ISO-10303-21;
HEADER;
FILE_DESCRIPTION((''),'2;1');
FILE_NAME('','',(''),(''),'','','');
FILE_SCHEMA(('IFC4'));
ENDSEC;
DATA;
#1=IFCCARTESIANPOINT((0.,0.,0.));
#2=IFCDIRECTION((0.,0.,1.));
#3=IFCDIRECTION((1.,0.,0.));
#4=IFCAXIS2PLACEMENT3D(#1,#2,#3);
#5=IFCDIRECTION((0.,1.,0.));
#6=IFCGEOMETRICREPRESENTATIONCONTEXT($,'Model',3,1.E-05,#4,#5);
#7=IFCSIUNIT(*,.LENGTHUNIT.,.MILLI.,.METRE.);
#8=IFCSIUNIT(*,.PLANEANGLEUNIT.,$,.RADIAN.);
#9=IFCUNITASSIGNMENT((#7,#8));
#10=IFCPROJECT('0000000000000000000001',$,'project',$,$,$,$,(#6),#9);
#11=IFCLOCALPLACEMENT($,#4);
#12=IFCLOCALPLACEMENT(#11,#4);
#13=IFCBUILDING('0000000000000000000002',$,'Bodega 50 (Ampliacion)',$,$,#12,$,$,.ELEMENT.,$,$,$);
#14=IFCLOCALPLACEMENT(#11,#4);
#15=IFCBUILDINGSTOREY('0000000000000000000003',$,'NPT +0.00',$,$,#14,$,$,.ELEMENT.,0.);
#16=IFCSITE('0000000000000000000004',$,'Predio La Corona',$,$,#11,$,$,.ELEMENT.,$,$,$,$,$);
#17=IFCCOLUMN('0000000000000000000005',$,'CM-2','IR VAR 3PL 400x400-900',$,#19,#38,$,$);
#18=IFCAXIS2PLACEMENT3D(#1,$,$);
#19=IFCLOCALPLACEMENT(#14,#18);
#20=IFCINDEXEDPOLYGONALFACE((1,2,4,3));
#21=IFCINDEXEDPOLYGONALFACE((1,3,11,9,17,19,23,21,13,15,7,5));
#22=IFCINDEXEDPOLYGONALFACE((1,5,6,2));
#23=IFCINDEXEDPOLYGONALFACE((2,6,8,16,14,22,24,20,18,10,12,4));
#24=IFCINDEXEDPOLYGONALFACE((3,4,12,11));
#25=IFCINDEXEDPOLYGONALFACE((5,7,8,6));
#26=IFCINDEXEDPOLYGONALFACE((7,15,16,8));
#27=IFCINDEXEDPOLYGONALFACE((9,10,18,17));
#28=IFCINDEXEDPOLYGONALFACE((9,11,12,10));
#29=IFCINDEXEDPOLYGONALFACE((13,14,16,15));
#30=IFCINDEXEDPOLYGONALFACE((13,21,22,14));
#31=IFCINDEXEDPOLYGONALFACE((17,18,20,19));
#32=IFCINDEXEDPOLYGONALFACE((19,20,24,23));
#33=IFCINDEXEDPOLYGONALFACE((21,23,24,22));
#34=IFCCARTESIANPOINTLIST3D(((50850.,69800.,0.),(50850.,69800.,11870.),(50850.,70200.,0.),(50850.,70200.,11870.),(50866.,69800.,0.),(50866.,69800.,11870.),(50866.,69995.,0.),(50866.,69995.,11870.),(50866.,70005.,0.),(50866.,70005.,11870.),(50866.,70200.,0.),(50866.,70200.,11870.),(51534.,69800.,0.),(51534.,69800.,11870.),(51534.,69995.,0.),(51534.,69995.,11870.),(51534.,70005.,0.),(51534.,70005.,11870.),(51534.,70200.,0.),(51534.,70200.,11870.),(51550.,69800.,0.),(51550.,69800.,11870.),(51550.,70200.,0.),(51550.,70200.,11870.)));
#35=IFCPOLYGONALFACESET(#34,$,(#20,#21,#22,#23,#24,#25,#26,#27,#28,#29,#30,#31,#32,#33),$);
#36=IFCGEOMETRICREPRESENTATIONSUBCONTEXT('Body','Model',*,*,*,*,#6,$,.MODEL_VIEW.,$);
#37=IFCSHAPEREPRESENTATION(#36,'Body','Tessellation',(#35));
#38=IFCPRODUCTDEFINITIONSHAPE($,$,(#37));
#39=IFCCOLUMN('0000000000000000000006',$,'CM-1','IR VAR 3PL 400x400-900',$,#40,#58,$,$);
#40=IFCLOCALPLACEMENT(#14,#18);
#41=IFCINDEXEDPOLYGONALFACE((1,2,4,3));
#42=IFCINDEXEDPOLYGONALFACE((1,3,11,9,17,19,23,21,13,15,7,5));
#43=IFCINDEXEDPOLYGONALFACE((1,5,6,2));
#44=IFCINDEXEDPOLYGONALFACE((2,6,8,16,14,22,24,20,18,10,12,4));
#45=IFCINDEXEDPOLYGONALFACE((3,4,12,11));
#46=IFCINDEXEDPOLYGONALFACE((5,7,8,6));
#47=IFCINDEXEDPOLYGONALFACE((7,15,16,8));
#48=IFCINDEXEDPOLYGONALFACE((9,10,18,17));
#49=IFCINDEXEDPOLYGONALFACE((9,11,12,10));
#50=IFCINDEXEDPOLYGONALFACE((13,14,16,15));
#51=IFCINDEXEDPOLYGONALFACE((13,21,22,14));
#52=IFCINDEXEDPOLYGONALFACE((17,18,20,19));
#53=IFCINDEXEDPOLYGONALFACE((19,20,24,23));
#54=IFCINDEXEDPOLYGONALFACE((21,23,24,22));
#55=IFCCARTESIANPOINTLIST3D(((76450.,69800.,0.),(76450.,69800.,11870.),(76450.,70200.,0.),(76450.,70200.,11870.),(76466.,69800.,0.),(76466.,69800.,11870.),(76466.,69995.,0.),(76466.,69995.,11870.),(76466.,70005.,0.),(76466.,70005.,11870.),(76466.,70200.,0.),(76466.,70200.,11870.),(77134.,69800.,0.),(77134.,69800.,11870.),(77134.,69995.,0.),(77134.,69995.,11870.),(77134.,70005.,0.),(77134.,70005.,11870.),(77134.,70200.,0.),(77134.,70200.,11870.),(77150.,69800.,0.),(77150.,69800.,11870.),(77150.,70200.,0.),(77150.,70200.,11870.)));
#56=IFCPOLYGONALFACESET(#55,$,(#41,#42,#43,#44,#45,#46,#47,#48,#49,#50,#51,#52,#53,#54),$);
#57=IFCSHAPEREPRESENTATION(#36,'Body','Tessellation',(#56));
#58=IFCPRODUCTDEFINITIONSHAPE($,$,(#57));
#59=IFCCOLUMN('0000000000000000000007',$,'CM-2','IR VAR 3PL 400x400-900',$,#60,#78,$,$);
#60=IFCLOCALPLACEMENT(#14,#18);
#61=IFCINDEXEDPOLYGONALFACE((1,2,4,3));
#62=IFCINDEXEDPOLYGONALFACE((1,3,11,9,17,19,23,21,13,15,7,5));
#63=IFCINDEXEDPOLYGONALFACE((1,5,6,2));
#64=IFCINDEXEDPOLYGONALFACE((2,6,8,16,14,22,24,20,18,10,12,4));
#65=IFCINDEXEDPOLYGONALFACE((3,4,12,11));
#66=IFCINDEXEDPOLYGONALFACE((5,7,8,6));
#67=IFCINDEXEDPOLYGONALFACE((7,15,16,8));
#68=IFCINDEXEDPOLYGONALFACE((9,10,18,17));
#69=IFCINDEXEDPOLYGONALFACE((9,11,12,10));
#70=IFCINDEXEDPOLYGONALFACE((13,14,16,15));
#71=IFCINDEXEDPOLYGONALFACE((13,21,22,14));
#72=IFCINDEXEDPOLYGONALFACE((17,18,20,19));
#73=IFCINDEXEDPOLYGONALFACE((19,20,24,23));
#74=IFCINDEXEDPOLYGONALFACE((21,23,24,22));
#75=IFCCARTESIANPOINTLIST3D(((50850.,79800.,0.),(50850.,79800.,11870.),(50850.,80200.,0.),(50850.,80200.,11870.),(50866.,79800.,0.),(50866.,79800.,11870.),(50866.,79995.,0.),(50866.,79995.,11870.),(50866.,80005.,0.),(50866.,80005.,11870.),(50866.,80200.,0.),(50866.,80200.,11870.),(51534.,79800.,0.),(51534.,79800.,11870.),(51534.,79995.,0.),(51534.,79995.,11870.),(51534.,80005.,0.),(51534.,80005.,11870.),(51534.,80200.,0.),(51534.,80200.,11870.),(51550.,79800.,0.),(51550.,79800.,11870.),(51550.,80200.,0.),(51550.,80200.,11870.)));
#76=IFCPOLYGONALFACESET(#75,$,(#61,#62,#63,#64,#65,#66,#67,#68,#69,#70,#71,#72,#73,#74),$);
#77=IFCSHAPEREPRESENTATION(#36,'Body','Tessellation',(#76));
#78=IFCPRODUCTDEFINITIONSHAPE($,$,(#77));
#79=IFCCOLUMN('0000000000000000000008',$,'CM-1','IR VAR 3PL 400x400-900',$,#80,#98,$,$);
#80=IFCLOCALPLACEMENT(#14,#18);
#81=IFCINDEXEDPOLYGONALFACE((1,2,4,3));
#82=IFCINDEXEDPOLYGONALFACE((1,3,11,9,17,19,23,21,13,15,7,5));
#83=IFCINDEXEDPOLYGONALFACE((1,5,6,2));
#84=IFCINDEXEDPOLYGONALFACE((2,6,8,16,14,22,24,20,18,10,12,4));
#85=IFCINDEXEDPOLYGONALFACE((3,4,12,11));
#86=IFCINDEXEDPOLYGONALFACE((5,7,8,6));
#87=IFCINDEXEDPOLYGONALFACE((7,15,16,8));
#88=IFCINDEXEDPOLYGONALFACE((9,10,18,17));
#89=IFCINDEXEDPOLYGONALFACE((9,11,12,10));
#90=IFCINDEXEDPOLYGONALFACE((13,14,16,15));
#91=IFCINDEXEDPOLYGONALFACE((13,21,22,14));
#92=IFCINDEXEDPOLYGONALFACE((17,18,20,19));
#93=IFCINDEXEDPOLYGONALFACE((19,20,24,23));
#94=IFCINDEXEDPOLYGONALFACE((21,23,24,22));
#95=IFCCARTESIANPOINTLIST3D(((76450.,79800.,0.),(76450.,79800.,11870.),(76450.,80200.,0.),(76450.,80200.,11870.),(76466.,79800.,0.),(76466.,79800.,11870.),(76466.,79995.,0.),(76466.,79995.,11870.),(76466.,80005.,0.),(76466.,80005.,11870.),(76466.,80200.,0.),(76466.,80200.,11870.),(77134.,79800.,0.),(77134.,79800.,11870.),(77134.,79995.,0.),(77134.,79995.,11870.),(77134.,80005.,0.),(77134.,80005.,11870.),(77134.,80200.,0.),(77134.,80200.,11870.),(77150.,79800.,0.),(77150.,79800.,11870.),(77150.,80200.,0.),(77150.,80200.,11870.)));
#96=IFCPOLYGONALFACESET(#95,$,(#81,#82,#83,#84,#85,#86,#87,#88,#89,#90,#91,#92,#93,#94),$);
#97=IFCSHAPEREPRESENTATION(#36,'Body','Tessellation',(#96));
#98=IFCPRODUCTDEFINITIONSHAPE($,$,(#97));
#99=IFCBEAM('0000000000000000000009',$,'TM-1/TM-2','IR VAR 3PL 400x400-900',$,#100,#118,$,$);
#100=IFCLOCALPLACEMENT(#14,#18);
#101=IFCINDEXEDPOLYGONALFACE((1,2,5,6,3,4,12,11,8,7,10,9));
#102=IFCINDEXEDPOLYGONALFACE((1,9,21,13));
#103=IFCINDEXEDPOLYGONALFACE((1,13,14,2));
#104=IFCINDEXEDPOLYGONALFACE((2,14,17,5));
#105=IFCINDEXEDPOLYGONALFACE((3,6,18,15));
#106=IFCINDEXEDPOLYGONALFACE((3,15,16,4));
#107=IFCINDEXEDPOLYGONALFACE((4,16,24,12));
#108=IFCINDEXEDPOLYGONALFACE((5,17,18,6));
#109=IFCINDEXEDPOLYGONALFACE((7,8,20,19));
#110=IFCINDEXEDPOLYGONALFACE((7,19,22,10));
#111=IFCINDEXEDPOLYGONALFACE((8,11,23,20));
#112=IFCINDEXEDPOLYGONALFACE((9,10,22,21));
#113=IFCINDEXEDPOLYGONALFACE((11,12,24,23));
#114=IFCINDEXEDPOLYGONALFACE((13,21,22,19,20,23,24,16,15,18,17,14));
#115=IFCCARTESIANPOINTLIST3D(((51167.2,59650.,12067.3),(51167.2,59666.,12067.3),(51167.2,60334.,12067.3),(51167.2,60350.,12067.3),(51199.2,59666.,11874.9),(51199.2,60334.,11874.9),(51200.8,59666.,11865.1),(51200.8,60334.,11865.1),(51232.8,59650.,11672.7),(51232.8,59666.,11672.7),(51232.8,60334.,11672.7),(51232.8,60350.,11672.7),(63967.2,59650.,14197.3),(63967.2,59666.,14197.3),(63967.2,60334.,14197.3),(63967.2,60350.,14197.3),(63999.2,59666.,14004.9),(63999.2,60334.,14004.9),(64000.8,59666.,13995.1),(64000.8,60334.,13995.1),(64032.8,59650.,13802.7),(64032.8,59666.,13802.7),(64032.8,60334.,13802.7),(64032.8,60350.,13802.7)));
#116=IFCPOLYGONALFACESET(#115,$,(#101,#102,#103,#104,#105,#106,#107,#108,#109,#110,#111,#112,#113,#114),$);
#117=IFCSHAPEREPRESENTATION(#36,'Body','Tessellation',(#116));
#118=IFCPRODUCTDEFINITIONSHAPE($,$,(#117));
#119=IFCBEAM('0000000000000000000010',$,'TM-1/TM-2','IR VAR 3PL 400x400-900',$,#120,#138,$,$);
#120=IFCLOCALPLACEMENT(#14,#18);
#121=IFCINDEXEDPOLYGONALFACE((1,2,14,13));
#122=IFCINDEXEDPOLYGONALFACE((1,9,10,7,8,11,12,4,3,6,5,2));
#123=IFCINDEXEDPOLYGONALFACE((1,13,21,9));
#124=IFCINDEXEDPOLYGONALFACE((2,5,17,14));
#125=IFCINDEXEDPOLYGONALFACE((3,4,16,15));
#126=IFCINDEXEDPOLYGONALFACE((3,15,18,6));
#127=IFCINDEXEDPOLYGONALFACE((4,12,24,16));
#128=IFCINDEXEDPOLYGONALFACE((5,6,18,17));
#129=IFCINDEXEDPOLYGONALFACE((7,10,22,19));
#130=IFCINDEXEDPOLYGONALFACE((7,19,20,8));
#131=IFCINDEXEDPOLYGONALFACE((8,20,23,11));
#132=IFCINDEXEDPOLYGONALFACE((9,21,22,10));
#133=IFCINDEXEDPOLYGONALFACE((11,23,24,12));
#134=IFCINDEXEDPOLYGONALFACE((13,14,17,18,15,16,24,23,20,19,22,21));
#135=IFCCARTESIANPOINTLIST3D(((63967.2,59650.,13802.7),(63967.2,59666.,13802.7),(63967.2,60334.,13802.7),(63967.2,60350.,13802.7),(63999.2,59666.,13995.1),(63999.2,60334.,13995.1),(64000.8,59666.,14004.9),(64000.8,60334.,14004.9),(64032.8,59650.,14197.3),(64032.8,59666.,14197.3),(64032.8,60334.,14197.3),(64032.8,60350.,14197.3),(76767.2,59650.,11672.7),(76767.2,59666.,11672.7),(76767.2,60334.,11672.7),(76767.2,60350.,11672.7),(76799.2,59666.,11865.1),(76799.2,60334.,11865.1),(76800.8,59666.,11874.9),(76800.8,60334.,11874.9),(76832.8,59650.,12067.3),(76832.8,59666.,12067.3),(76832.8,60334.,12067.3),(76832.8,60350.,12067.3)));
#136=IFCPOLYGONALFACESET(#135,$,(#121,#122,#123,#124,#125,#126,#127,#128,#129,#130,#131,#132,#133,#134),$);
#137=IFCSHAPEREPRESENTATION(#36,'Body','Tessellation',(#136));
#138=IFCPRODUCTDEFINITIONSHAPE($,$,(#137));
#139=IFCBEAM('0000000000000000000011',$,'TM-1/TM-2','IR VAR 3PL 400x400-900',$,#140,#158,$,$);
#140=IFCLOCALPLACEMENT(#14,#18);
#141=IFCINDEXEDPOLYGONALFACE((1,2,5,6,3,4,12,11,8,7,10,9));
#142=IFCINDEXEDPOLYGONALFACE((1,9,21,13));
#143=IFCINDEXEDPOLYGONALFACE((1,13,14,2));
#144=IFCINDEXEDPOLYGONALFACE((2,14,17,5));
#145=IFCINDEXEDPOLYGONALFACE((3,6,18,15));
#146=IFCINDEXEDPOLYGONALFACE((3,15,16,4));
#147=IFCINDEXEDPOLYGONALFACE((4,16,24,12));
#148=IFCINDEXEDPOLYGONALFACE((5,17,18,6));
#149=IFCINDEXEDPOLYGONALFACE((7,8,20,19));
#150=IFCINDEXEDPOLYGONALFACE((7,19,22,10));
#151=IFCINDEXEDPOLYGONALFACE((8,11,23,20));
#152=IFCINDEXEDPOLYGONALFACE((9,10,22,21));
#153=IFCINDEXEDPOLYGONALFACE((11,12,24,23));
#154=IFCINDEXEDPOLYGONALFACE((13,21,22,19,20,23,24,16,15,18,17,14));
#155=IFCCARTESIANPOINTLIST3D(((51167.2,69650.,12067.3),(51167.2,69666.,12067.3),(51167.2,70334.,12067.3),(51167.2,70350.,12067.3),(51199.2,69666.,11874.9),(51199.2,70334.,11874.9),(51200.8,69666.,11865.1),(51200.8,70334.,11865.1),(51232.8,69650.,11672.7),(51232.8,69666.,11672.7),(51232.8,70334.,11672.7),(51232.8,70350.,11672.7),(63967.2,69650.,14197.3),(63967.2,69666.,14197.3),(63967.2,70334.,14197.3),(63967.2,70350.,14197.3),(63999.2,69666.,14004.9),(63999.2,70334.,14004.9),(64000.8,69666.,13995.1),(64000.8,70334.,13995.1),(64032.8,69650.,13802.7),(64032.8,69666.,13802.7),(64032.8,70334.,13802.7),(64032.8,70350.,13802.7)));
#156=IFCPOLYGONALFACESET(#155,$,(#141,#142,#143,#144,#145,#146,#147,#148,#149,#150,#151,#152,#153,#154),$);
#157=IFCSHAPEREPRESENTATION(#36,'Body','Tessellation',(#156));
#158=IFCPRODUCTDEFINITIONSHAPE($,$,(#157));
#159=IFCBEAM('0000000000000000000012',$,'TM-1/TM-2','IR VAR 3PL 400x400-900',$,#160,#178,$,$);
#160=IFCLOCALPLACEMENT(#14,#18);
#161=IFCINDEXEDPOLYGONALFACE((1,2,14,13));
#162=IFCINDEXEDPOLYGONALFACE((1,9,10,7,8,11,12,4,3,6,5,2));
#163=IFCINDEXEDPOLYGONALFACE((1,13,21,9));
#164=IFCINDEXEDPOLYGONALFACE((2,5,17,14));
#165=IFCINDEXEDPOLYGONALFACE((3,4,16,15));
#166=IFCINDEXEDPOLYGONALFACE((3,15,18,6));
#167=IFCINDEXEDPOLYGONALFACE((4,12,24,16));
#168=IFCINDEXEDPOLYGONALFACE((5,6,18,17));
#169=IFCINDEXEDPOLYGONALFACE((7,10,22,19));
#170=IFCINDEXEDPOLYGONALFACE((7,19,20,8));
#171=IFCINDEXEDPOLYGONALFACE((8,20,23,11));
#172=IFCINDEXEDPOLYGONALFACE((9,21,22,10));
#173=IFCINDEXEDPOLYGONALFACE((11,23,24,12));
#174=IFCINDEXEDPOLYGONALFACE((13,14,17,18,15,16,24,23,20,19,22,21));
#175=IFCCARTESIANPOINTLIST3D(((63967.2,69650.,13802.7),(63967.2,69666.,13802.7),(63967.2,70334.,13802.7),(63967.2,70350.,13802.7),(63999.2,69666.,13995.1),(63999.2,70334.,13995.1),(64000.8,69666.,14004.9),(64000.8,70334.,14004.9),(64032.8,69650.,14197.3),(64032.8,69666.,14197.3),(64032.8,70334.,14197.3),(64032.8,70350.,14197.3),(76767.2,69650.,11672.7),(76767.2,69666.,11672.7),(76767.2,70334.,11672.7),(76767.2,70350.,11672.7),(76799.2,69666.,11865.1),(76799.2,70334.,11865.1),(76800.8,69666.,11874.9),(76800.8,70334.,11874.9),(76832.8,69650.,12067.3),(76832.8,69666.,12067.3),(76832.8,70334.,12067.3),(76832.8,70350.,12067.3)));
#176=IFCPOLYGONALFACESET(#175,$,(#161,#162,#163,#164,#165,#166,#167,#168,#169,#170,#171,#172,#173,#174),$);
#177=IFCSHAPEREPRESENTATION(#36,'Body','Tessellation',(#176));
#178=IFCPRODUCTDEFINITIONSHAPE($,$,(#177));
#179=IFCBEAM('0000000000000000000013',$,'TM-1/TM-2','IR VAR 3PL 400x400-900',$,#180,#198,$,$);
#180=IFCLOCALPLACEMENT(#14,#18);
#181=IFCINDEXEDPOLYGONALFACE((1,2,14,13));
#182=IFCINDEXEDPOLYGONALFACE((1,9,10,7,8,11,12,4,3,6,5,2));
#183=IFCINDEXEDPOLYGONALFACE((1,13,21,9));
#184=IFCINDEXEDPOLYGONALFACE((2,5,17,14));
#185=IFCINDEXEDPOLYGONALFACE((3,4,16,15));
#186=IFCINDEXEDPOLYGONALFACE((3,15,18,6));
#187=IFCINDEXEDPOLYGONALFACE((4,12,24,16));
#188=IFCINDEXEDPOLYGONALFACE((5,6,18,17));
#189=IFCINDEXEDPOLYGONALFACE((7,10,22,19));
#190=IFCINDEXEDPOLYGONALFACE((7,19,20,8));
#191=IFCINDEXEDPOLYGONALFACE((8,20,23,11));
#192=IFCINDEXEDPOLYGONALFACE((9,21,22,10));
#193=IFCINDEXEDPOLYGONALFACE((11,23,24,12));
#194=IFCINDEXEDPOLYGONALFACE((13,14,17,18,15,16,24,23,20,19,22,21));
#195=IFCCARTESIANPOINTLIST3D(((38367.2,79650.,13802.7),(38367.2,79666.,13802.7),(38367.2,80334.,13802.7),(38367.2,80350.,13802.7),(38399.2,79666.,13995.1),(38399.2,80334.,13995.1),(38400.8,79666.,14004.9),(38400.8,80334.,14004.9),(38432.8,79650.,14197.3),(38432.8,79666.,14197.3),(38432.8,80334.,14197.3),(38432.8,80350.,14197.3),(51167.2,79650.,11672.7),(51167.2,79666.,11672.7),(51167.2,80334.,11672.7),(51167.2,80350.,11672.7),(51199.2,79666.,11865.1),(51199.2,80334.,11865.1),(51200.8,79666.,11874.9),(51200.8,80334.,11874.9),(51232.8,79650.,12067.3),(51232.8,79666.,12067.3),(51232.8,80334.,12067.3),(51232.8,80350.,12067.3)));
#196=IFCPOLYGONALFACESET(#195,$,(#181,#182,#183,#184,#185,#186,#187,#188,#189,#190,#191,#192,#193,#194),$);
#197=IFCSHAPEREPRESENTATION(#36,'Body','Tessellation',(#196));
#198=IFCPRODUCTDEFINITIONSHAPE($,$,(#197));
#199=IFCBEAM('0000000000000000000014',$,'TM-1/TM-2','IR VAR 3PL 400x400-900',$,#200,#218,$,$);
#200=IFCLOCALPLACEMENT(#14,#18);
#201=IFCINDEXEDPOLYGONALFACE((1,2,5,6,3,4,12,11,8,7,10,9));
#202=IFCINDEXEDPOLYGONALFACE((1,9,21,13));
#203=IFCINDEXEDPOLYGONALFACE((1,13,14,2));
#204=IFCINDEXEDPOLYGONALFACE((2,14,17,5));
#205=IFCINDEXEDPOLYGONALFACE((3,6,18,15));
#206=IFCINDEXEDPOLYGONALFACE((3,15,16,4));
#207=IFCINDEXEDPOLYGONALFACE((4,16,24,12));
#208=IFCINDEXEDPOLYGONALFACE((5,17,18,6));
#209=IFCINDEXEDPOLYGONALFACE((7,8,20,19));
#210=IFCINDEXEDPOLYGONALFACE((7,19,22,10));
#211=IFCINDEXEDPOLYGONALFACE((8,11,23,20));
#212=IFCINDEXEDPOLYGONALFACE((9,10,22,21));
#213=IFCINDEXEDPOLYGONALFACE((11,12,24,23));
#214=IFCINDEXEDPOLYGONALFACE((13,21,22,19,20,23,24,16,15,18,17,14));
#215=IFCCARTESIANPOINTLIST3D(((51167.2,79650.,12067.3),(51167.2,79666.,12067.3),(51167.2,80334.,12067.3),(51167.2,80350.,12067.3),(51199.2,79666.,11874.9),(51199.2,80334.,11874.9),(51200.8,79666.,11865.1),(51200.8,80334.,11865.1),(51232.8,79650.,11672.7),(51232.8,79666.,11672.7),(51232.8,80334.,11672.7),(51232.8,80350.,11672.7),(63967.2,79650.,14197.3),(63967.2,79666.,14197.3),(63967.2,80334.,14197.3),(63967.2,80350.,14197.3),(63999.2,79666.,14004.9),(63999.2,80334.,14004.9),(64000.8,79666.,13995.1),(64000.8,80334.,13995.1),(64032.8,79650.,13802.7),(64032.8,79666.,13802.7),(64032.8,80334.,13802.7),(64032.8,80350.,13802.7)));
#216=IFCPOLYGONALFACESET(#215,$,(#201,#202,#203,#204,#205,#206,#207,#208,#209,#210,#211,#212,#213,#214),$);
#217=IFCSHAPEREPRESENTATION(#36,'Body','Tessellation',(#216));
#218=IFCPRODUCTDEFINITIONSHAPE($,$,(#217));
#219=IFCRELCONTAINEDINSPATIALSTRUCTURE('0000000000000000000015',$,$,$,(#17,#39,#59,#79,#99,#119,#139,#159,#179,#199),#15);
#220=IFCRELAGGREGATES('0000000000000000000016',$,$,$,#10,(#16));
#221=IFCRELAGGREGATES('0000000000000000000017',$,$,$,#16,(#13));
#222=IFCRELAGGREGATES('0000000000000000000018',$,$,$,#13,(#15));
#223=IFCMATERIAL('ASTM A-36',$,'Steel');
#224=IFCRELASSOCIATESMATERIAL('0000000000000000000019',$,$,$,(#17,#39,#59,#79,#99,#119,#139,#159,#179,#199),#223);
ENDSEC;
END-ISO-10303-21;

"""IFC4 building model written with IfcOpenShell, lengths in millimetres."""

from ifc_helpers import new_model, si_unit, direction, frame, origin_with_axes, origin_2d, place, context, subcontext, project, spatial, i_section, extrude, material, element, save


model = new_model("IFC4")

# Units and contexts
model_context = context("Model", 3, precision=1e-05, world=origin_with_axes(), true_north=direction((0.0, 1.0, 0.0)))
body_context = subcontext(model_context, "Body", "Model", "MODEL_VIEW")
ifc_project = project(units=[si_unit("LENGTHUNIT", "METRE", prefix="MILLI"), si_unit("PLANEANGLEUNIT", "RADIAN")], contexts=[model_context])

# Site, building, storey
site_placement = place(None, origin_with_axes())
site = spatial("IfcSite", under=ifc_project, at=site_placement, Name="Predio La Corona", CompositionType="ELEMENT")
building_placement = place(site_placement, origin_with_axes())
building = spatial("IfcBuilding", under=site, at=building_placement, Name="Bodega 50 (Ampliacion)", CompositionType="ELEMENT")
storey_placement = place(site_placement, origin_with_axes())
storey = spatial("IfcBuildingStorey", under=building, at=storey_placement, Name="NPT +0.00", CompositionType="ELEMENT", Elevation=0.0)

# Columns
ifc_material = material(Name="ASTM A-36", Category="Steel")
for number, where, z_axis, x_axis, name in (
    (1, (51200.0, 70000.0, 0.0), (0.0, 0.0, 1.0), (0.0, -1.0, 0.0), "CM-2"),
    (2, (76800.0, 70000.0, 0.0), (0.0, 0.0, 1.0), (0.0, -1.0, 0.0), "CM-1"),
    (3, (51200.0, 80000.0, 0.0), (0.0, 0.0, 1.0), (0.0, -1.0, 0.0), "CM-2"),
    (4, (76800.0, 80000.0, 0.0), (0.0, 0.0, 1.0), (0.0, -1.0, 0.0), "CM-1"),
):
    element("IfcColumn", number, at=place(storey_placement, frame(where, z_axis=z_axis, x_axis=x_axis)), inside=storey, material=ifc_material, Name=name, Description="IR VAR 3PL 400x400-900", context=body_context, shape_type="SweptSolid", body=[
        extrude(i_section(OverallWidth=400.0, OverallDepth=700.0, WebThickness=10.0, FlangeThickness=16.0, at=origin_2d()), origin_with_axes(), (0.0, 0.0, 1.0), 11870.0),
    ])

# Beams
for number, where, z_axis, x_axis, name in (
    (5, (51200.0, 60000.0, 11870.0), (0.986436, 0.0, 0.164149), (0.164149, 0.0, -0.986436), "TM-1/TM-2"),
    (6, (64000.0, 60000.0, 14000.0), (0.986436, 0.0, -0.164149), (-0.164149, 0.0, -0.986436), "TM-1/TM-2"),
    (7, (51200.0, 70000.0, 11870.0), (0.986436, 0.0, 0.164149), (0.164149, 0.0, -0.986436), "TM-1/TM-2"),
    (8, (64000.0, 70000.0, 14000.0), (0.986436, 0.0, -0.164149), (-0.164149, 0.0, -0.986436), "TM-1/TM-2"),
    (9, (38400.0, 80000.0, 14000.0), (0.986436, 0.0, -0.164149), (-0.164149, 0.0, -0.986436), "TM-1/TM-2"),
    (10, (51200.0, 80000.0, 11870.0), (0.986436, 0.0, 0.164149), (0.164149, 0.0, -0.986436), "TM-1/TM-2"),
):
    element("IfcBeam", number, at=place(storey_placement, frame(where, z_axis=z_axis, x_axis=x_axis)), inside=storey, material=ifc_material, Name=name, Description="IR VAR 3PL 400x400-900", context=body_context, shape_type="SweptSolid", body=[
        extrude(i_section(OverallWidth=400.0, OverallDepth=700.0, WebThickness=10.0, FlangeThickness=16.0, at=origin_2d()), origin_with_axes(), (0.0, 0.0, 1.0), 12976.0),
    ])

save(model, "model.ifc")
